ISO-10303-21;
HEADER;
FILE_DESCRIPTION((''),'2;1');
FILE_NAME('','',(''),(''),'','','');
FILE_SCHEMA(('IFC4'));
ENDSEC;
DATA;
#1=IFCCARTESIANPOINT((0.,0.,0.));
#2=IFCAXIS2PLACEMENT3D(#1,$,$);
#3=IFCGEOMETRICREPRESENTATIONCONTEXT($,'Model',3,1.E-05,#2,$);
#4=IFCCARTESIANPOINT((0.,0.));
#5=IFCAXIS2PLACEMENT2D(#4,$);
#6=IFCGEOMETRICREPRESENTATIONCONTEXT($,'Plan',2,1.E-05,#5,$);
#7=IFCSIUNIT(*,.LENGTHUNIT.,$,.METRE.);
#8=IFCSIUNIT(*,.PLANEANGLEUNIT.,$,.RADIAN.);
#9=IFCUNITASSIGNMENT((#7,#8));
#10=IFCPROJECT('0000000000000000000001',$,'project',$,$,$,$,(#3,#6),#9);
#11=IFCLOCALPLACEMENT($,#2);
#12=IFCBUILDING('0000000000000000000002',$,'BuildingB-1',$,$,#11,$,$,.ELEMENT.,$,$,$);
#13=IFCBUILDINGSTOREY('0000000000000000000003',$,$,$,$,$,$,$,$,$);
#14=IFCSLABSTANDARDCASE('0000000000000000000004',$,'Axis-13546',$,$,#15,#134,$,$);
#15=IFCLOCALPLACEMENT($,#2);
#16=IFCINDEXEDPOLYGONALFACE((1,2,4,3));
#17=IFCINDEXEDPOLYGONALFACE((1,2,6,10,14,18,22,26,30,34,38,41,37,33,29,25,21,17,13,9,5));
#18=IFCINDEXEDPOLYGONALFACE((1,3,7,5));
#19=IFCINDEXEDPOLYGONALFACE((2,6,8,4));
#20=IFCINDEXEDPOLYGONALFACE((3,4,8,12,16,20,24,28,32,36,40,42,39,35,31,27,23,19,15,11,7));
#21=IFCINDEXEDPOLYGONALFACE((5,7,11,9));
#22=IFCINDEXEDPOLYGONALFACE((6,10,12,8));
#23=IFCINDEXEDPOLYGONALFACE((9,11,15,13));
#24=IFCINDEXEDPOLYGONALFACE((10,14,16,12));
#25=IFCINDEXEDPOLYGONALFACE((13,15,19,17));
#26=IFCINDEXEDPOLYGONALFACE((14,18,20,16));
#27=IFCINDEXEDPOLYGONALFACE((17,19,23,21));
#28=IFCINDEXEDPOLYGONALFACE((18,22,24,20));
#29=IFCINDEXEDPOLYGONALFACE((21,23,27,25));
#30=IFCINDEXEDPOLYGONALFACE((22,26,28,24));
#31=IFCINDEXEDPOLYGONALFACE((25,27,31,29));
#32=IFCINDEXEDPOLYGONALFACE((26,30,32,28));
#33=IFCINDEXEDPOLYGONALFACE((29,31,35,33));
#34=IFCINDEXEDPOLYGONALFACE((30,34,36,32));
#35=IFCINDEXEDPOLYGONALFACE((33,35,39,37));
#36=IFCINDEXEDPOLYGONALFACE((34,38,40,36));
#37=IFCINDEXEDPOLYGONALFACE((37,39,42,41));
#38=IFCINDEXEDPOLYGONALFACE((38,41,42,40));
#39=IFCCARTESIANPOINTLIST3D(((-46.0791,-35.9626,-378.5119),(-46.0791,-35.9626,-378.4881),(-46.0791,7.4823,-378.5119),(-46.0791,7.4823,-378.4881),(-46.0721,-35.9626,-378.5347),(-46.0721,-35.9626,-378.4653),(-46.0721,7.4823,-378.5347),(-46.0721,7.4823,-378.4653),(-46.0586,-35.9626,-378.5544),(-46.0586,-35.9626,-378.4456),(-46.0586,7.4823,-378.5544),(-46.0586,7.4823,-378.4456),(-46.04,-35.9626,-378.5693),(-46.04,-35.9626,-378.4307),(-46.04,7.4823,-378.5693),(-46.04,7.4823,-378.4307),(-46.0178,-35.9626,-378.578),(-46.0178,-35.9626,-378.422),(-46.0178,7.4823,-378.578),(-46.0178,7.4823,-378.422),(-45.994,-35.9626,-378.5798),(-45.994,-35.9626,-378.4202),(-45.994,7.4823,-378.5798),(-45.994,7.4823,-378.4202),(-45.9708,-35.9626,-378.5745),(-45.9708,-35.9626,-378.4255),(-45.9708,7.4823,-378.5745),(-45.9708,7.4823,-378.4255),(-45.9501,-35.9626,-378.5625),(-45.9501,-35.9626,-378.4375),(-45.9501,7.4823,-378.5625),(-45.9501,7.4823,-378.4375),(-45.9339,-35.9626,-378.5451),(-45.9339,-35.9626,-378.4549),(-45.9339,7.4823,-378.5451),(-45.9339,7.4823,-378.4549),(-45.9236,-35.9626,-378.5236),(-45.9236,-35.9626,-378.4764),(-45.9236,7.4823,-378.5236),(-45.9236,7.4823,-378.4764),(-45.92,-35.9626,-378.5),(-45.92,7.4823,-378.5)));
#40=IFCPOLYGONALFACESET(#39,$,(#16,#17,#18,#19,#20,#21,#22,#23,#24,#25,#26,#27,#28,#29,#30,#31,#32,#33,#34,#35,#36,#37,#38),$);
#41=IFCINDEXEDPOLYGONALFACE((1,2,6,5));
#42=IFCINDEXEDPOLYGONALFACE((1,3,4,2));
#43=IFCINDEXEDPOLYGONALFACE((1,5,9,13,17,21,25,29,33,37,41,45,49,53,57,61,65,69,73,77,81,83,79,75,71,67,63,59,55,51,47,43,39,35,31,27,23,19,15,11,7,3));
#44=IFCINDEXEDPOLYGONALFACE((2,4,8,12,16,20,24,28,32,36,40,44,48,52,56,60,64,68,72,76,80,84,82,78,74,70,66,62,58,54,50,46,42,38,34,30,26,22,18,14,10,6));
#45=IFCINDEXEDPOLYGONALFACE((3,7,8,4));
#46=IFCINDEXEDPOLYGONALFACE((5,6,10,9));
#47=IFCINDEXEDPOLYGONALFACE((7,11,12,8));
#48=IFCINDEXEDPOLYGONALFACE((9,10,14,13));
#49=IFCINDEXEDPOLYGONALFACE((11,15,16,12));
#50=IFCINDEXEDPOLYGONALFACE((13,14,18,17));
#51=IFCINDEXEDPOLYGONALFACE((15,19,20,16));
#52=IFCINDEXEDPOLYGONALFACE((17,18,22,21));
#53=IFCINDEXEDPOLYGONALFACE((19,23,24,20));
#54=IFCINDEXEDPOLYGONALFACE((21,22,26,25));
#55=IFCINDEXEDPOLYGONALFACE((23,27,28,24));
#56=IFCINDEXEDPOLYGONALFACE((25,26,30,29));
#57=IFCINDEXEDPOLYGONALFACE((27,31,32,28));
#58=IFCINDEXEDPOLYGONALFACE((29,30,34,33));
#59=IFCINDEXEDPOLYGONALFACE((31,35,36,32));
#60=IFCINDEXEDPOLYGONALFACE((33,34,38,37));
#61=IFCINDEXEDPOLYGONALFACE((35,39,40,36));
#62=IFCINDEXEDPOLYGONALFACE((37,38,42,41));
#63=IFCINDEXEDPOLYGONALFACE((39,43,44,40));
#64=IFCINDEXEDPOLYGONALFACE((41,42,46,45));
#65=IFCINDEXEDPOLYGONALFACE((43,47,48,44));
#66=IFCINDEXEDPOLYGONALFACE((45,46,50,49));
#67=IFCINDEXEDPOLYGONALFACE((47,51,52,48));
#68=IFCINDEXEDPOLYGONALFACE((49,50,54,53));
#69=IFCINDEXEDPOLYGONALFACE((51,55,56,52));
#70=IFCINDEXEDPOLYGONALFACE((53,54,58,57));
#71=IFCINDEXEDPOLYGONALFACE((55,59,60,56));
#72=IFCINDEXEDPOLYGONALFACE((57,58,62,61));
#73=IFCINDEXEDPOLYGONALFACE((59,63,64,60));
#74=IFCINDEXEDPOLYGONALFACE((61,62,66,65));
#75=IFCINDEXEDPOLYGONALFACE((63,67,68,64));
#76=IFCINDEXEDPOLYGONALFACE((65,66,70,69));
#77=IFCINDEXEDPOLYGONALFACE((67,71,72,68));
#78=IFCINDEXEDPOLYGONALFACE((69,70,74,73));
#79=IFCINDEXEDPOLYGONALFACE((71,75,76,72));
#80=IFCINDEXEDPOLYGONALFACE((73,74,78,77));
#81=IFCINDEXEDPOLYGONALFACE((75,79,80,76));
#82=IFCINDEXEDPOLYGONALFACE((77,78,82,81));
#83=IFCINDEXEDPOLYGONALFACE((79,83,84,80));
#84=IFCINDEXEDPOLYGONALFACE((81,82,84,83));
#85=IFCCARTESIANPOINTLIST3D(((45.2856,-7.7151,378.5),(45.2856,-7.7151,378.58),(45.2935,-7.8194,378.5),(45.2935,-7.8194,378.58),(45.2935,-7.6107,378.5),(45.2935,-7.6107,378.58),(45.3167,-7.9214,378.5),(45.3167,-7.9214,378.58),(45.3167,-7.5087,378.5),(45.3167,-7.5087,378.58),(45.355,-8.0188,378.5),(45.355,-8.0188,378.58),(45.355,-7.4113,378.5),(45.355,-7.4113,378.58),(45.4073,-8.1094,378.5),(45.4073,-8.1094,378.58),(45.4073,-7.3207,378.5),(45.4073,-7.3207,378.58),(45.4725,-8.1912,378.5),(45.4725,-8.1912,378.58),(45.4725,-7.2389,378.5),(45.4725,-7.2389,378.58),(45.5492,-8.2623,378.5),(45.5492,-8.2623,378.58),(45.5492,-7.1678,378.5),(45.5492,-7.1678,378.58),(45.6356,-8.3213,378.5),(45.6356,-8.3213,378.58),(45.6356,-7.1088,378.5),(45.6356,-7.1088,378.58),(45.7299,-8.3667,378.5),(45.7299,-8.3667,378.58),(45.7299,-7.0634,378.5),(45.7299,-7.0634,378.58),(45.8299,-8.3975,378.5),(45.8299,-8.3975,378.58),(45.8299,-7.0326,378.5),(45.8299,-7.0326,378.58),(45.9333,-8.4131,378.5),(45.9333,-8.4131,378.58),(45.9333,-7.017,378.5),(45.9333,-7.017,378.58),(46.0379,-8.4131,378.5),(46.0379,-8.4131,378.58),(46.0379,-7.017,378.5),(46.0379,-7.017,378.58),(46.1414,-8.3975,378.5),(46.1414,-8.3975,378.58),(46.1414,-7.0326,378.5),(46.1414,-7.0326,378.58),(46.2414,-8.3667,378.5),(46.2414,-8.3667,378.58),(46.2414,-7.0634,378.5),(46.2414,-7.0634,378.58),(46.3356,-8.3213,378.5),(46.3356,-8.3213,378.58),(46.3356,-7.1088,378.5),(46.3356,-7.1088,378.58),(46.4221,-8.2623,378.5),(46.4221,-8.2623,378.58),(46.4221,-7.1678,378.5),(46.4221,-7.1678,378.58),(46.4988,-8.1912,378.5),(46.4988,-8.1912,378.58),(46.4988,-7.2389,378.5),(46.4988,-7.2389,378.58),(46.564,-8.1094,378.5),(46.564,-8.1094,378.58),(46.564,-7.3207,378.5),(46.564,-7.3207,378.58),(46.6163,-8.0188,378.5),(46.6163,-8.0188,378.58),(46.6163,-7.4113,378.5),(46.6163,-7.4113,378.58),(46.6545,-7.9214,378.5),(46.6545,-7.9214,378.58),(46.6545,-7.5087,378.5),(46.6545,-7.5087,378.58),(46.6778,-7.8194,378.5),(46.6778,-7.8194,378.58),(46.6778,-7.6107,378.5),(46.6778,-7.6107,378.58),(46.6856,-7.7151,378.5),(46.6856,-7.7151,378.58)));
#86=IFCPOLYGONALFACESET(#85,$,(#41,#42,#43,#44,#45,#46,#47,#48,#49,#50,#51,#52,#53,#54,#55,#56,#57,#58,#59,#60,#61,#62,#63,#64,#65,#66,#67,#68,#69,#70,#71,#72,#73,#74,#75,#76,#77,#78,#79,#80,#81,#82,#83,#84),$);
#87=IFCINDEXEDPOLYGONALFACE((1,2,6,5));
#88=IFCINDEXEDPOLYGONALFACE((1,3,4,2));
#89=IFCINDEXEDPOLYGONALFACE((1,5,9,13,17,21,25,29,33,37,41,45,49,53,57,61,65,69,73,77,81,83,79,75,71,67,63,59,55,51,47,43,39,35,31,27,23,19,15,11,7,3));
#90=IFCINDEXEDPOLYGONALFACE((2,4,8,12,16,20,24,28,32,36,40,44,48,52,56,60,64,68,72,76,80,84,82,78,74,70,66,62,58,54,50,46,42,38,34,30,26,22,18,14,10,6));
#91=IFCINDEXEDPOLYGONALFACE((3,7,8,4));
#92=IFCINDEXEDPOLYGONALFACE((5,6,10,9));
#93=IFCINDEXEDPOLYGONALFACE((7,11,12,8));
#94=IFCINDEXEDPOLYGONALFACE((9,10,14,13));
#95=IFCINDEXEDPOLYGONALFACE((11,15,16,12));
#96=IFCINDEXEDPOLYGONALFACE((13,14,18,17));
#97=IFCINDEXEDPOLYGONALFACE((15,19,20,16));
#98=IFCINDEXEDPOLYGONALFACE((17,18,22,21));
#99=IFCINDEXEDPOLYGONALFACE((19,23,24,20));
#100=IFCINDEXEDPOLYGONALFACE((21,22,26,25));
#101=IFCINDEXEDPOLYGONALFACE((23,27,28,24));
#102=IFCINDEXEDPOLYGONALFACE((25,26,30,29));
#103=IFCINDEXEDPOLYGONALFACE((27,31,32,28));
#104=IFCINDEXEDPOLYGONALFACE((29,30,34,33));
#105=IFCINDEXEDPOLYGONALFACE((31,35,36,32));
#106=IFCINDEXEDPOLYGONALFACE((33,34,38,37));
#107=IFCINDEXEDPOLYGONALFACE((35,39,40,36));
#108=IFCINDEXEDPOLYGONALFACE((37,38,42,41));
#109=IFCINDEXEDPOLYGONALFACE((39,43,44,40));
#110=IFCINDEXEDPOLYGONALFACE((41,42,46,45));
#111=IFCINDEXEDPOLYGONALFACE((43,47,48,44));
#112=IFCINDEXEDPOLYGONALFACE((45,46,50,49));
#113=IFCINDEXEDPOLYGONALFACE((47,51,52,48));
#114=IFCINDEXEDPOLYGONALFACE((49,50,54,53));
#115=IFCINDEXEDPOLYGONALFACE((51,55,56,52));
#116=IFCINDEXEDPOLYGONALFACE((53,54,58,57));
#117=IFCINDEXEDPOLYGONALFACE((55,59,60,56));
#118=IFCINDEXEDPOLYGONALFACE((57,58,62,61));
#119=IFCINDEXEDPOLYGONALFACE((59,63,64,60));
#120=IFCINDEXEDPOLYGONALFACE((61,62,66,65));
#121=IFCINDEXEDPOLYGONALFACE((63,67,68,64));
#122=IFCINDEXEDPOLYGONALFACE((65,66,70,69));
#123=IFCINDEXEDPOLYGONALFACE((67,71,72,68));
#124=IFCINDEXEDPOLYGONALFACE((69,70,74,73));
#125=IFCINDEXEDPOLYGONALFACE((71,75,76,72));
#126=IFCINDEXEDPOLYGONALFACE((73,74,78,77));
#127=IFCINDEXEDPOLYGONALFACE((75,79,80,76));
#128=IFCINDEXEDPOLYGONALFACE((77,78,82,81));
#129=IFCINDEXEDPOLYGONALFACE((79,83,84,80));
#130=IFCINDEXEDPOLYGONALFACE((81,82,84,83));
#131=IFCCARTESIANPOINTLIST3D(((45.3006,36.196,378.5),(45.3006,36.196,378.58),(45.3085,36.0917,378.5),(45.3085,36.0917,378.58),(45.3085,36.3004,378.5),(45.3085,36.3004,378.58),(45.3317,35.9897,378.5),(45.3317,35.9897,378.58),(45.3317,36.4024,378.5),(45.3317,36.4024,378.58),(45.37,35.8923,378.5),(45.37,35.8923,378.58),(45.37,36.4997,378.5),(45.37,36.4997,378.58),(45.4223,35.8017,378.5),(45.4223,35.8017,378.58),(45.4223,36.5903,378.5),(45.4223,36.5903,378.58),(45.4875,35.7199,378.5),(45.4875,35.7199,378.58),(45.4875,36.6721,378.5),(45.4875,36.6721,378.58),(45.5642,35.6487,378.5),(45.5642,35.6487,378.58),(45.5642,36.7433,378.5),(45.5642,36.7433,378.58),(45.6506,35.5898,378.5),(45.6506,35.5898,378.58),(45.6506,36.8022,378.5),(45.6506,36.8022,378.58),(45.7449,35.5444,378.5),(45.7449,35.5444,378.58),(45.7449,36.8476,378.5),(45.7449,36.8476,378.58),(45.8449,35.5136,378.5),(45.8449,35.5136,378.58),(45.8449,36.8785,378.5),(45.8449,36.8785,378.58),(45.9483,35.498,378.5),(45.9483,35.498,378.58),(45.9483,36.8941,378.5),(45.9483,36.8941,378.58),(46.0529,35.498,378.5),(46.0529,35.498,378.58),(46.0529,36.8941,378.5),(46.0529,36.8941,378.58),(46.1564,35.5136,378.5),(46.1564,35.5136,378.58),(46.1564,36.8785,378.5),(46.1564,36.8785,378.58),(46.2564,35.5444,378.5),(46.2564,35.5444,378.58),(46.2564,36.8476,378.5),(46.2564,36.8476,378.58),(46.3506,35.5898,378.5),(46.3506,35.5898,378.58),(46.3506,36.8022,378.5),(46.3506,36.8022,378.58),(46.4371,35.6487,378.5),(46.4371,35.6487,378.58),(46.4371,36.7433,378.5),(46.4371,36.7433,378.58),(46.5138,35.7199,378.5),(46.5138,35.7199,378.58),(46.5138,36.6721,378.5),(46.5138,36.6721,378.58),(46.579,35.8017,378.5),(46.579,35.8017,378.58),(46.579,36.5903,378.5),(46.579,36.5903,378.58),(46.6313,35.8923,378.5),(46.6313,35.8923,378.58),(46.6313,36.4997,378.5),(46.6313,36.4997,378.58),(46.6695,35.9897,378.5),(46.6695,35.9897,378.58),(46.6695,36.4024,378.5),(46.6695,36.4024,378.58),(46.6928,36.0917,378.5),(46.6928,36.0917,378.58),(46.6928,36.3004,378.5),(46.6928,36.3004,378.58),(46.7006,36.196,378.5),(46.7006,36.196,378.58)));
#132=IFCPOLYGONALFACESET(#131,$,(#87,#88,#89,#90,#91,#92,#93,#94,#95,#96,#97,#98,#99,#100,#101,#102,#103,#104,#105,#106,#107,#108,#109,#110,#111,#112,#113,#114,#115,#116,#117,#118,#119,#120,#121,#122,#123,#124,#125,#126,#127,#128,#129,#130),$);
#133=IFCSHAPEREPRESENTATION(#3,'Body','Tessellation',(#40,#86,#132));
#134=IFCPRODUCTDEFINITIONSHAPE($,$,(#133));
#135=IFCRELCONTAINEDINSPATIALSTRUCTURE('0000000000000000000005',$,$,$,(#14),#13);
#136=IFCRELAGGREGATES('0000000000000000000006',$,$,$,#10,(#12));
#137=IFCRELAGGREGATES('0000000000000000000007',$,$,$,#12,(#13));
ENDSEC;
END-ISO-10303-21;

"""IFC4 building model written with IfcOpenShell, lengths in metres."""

from ifc_helpers import new_model, entity, si_unit, frame, origin, origin_2d, place, context, project, spatial, circle, extrude, element, save


model = new_model("IFC4")

# Units and contexts
model_context = context("Model", 3, precision=1e-05, world=origin())
plan_context = context("Plan", 2, precision=1e-05, world=origin_2d())
ifc_project = project(units=[si_unit("LENGTHUNIT", "METRE"), si_unit("PLANEANGLEUNIT", "RADIAN")], contexts=[model_context, plan_context])

# Building, storey
building_placement = place(None, origin())
building = spatial("IfcBuilding", under=ifc_project, at=building_placement, Name="BuildingB-1", CompositionType="ELEMENT")
storey = spatial("IfcBuildingStorey", under=building)

# Slab
element("IfcSlabStandardCase", 1, inside=storey, Name="Axis-13546", context=model_context, shape_type="AdvancedSweptSolid", body=[
    entity("IfcSurfaceCurveSweptAreaSolid", entity("IfcCircleProfileDef", "AREA", None, None, 0.08), None, entity("IfcPolyline", [entity("IfcCartesianPoint", [46.0, -7.4823, 378.5]), entity("IfcCartesianPoint", [46.0, 35.9626, 378.5])]), None, None, entity("IfcPlane", entity("IfcAxis2Placement3D", entity("IfcCartesianPoint", [46.0, -7.4823, 378.5]), entity("IfcDirection", [0.0, 0.0, 1.0]), entity("IfcDirection", [1.0, 0.0, 0.0])))),
    extrude(circle(Radius=0.7), frame((45.9856, -7.7151, 378.5)), (0.0, 0.0, 1.0), 0.08),
    extrude(circle(Radius=0.7), frame((46.0006, 36.196, 378.5)), (0.0, 0.0, 1.0), 0.08),
])

save(model, "model.ifc")
